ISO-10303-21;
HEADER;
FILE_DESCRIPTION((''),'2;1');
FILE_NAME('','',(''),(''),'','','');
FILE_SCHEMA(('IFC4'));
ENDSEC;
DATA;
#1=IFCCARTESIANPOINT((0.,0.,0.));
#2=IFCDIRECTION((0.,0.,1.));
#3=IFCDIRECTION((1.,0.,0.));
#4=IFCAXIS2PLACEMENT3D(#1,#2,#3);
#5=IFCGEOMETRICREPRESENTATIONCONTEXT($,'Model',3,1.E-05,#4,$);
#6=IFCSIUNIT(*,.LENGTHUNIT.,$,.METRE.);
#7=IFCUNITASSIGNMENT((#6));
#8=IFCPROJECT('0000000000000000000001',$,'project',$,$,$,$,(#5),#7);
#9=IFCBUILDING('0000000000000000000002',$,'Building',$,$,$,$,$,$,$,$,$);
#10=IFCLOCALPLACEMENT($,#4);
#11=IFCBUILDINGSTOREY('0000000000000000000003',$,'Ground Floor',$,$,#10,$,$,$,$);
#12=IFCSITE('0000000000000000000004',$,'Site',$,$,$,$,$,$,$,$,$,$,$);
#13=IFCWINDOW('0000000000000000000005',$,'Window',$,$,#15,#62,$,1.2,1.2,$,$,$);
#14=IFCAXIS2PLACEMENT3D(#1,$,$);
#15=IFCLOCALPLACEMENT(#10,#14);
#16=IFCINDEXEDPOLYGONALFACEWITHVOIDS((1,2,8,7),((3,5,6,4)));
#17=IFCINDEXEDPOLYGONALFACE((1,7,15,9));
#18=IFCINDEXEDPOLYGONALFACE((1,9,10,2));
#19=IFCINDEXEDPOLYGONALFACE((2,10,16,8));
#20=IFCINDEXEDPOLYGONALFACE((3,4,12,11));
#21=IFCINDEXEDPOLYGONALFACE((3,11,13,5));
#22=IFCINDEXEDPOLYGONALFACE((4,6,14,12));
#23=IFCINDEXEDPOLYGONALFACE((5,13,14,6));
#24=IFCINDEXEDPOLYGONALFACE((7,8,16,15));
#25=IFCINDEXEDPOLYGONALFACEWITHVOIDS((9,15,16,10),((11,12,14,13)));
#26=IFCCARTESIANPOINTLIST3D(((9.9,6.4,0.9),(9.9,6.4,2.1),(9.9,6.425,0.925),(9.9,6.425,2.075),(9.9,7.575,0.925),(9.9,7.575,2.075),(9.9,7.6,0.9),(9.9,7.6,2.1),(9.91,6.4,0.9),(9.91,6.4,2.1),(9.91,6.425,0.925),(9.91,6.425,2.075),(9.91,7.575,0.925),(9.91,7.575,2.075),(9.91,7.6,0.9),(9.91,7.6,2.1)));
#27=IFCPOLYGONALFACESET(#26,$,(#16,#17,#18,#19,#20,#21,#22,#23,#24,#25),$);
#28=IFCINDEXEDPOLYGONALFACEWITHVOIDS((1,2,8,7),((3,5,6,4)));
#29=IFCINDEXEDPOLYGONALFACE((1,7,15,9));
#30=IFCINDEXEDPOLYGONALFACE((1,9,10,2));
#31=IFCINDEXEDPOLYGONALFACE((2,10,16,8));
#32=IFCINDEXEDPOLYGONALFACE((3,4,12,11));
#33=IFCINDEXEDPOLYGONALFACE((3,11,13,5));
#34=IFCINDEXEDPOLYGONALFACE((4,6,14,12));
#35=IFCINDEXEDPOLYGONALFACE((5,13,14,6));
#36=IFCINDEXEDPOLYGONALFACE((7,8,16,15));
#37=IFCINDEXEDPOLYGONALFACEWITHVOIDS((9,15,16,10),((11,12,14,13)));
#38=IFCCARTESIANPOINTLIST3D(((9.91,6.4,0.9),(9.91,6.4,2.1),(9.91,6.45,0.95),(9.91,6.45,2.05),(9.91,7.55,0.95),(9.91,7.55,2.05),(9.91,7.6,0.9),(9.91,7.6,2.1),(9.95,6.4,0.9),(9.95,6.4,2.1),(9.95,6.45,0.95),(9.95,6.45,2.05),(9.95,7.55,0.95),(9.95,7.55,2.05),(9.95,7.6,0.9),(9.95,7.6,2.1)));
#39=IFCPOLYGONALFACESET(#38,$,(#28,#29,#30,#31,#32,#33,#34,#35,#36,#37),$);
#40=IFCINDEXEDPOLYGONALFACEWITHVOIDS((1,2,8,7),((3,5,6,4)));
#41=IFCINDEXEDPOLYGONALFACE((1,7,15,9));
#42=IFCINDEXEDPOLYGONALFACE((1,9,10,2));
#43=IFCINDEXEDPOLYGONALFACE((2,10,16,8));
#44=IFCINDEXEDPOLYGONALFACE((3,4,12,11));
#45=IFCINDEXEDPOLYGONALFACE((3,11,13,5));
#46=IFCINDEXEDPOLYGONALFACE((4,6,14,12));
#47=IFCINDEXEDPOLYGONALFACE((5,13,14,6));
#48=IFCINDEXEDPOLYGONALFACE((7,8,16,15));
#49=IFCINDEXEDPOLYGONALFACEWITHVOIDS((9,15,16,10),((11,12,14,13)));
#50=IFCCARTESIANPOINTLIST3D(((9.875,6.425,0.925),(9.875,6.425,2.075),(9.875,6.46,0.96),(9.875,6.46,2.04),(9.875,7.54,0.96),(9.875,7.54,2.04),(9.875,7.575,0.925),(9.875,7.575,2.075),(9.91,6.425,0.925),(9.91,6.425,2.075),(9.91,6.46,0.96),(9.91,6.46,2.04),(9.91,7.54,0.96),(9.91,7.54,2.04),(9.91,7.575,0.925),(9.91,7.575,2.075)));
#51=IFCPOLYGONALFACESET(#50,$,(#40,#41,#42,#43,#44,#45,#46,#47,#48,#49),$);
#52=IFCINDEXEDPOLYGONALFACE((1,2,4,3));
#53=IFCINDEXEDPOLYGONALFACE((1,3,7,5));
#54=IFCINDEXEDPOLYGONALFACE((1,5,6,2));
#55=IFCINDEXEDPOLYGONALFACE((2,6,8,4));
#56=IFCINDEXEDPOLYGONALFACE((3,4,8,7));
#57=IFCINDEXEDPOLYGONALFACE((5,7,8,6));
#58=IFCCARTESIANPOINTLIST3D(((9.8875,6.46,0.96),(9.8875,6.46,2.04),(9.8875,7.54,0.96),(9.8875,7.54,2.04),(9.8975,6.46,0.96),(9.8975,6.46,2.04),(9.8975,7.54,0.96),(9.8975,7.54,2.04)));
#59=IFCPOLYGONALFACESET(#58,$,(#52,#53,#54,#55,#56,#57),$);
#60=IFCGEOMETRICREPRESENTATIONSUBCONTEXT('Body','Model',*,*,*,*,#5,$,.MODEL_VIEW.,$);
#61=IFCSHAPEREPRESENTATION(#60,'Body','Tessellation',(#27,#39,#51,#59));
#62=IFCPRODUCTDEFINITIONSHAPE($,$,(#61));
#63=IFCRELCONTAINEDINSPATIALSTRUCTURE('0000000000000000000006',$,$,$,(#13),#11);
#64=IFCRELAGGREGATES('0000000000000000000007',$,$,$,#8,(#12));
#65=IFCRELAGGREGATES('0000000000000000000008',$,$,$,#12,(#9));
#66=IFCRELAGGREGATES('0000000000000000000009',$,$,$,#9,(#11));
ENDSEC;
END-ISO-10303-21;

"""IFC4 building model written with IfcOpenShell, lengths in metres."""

from ifc_helpers import new_model, si_unit, frame, origin_with_axes, place, context, subcontext, project, spatial, line, indexed_curve, outline, extrude, element, save


model = new_model("IFC4")

# Units and contexts
model_context = context("Model", 3, precision=1e-05, world=origin_with_axes())
body_context = subcontext(model_context, "Body", "Model", "MODEL_VIEW")
ifc_project = project(units=[si_unit("LENGTHUNIT", "METRE")], contexts=[model_context])

# Site, building, storey
site = spatial("IfcSite", under=ifc_project, Name="Site")
building = spatial("IfcBuilding", under=site, Name="Building")
storey_placement = place(None, origin_with_axes())
storey = spatial("IfcBuildingStorey", under=building, at=storey_placement, Name="Ground Floor")

# Window
window_placement = place(storey_placement, frame((10.0, 6.4, 0.9), z_axis=(0.0, 0.0, 1.0), x_axis=(0.0, 1.0, 0.0)))
element("IfcWindow", 1, at=window_placement, inside=storey, Name="Window", OverallHeight=1.2, OverallWidth=1.2, context=body_context, shape_type="SweptSolid", body=[
    extrude(outline(indexed_curve([(0.0, 0.0), (1.2, 0.0), (1.2, 1.2), (0.0, 1.2)], segments=[line(1, 2, 3, 4, 1)]), holes=[indexed_curve([(0.025, 0.025), (1.175, 0.025), (1.175, 1.175), (0.025, 1.175)], segments=[line(1, 2, 3, 4, 1)])]), frame((0.0, 0.09, 0.0), z_axis=(0.0, -1.0, 0.0), x_axis=(1.0, 0.0, 0.0)), (0.0, 0.0, -1.0), 0.01),
    extrude(outline(indexed_curve([(0.0, 0.0), (1.2, 0.0), (1.2, 1.2), (0.0, 1.2)], segments=[line(1, 2, 3, 4, 1)]), holes=[indexed_curve([(0.05, 0.05), (1.15, 0.05), (1.15, 1.15), (0.05, 1.15)], segments=[line(1, 2, 3, 4, 1)])]), frame((0.0, 0.05, 0.0), z_axis=(0.0, -1.0, 0.0), x_axis=(1.0, 0.0, 0.0)), (0.0, 0.0, -1.0), 0.04),
    extrude(outline(indexed_curve([(0.0, 0.0), (1.15, 0.0), (1.15, 1.15), (0.0, 1.15)], segments=[line(1, 2, 3, 4, 1)]), holes=[indexed_curve([(0.035, 0.035), (1.115, 0.035), (1.115, 1.115), (0.035, 1.115)], segments=[line(1, 2, 3, 4, 1)])]), frame((0.025, 0.09, 0.025), z_axis=(0.0, -1.0, 0.0), x_axis=(1.0, 0.0, 0.0)), (0.0, 0.0, -1.0), 0.035),
    extrude(outline(indexed_curve([(0.035, 0.035), (1.115, 0.035), (1.115, 1.115), (0.035, 1.115)], segments=[line(1, 2, 3, 4, 1)])), frame((0.025, 0.1025, 0.025), z_axis=(0.0, -1.0, 0.0), x_axis=(1.0, 0.0, 0.0)), (0.0, 0.0, -1.0), 0.01),
])

save(model, "model.ifc")
